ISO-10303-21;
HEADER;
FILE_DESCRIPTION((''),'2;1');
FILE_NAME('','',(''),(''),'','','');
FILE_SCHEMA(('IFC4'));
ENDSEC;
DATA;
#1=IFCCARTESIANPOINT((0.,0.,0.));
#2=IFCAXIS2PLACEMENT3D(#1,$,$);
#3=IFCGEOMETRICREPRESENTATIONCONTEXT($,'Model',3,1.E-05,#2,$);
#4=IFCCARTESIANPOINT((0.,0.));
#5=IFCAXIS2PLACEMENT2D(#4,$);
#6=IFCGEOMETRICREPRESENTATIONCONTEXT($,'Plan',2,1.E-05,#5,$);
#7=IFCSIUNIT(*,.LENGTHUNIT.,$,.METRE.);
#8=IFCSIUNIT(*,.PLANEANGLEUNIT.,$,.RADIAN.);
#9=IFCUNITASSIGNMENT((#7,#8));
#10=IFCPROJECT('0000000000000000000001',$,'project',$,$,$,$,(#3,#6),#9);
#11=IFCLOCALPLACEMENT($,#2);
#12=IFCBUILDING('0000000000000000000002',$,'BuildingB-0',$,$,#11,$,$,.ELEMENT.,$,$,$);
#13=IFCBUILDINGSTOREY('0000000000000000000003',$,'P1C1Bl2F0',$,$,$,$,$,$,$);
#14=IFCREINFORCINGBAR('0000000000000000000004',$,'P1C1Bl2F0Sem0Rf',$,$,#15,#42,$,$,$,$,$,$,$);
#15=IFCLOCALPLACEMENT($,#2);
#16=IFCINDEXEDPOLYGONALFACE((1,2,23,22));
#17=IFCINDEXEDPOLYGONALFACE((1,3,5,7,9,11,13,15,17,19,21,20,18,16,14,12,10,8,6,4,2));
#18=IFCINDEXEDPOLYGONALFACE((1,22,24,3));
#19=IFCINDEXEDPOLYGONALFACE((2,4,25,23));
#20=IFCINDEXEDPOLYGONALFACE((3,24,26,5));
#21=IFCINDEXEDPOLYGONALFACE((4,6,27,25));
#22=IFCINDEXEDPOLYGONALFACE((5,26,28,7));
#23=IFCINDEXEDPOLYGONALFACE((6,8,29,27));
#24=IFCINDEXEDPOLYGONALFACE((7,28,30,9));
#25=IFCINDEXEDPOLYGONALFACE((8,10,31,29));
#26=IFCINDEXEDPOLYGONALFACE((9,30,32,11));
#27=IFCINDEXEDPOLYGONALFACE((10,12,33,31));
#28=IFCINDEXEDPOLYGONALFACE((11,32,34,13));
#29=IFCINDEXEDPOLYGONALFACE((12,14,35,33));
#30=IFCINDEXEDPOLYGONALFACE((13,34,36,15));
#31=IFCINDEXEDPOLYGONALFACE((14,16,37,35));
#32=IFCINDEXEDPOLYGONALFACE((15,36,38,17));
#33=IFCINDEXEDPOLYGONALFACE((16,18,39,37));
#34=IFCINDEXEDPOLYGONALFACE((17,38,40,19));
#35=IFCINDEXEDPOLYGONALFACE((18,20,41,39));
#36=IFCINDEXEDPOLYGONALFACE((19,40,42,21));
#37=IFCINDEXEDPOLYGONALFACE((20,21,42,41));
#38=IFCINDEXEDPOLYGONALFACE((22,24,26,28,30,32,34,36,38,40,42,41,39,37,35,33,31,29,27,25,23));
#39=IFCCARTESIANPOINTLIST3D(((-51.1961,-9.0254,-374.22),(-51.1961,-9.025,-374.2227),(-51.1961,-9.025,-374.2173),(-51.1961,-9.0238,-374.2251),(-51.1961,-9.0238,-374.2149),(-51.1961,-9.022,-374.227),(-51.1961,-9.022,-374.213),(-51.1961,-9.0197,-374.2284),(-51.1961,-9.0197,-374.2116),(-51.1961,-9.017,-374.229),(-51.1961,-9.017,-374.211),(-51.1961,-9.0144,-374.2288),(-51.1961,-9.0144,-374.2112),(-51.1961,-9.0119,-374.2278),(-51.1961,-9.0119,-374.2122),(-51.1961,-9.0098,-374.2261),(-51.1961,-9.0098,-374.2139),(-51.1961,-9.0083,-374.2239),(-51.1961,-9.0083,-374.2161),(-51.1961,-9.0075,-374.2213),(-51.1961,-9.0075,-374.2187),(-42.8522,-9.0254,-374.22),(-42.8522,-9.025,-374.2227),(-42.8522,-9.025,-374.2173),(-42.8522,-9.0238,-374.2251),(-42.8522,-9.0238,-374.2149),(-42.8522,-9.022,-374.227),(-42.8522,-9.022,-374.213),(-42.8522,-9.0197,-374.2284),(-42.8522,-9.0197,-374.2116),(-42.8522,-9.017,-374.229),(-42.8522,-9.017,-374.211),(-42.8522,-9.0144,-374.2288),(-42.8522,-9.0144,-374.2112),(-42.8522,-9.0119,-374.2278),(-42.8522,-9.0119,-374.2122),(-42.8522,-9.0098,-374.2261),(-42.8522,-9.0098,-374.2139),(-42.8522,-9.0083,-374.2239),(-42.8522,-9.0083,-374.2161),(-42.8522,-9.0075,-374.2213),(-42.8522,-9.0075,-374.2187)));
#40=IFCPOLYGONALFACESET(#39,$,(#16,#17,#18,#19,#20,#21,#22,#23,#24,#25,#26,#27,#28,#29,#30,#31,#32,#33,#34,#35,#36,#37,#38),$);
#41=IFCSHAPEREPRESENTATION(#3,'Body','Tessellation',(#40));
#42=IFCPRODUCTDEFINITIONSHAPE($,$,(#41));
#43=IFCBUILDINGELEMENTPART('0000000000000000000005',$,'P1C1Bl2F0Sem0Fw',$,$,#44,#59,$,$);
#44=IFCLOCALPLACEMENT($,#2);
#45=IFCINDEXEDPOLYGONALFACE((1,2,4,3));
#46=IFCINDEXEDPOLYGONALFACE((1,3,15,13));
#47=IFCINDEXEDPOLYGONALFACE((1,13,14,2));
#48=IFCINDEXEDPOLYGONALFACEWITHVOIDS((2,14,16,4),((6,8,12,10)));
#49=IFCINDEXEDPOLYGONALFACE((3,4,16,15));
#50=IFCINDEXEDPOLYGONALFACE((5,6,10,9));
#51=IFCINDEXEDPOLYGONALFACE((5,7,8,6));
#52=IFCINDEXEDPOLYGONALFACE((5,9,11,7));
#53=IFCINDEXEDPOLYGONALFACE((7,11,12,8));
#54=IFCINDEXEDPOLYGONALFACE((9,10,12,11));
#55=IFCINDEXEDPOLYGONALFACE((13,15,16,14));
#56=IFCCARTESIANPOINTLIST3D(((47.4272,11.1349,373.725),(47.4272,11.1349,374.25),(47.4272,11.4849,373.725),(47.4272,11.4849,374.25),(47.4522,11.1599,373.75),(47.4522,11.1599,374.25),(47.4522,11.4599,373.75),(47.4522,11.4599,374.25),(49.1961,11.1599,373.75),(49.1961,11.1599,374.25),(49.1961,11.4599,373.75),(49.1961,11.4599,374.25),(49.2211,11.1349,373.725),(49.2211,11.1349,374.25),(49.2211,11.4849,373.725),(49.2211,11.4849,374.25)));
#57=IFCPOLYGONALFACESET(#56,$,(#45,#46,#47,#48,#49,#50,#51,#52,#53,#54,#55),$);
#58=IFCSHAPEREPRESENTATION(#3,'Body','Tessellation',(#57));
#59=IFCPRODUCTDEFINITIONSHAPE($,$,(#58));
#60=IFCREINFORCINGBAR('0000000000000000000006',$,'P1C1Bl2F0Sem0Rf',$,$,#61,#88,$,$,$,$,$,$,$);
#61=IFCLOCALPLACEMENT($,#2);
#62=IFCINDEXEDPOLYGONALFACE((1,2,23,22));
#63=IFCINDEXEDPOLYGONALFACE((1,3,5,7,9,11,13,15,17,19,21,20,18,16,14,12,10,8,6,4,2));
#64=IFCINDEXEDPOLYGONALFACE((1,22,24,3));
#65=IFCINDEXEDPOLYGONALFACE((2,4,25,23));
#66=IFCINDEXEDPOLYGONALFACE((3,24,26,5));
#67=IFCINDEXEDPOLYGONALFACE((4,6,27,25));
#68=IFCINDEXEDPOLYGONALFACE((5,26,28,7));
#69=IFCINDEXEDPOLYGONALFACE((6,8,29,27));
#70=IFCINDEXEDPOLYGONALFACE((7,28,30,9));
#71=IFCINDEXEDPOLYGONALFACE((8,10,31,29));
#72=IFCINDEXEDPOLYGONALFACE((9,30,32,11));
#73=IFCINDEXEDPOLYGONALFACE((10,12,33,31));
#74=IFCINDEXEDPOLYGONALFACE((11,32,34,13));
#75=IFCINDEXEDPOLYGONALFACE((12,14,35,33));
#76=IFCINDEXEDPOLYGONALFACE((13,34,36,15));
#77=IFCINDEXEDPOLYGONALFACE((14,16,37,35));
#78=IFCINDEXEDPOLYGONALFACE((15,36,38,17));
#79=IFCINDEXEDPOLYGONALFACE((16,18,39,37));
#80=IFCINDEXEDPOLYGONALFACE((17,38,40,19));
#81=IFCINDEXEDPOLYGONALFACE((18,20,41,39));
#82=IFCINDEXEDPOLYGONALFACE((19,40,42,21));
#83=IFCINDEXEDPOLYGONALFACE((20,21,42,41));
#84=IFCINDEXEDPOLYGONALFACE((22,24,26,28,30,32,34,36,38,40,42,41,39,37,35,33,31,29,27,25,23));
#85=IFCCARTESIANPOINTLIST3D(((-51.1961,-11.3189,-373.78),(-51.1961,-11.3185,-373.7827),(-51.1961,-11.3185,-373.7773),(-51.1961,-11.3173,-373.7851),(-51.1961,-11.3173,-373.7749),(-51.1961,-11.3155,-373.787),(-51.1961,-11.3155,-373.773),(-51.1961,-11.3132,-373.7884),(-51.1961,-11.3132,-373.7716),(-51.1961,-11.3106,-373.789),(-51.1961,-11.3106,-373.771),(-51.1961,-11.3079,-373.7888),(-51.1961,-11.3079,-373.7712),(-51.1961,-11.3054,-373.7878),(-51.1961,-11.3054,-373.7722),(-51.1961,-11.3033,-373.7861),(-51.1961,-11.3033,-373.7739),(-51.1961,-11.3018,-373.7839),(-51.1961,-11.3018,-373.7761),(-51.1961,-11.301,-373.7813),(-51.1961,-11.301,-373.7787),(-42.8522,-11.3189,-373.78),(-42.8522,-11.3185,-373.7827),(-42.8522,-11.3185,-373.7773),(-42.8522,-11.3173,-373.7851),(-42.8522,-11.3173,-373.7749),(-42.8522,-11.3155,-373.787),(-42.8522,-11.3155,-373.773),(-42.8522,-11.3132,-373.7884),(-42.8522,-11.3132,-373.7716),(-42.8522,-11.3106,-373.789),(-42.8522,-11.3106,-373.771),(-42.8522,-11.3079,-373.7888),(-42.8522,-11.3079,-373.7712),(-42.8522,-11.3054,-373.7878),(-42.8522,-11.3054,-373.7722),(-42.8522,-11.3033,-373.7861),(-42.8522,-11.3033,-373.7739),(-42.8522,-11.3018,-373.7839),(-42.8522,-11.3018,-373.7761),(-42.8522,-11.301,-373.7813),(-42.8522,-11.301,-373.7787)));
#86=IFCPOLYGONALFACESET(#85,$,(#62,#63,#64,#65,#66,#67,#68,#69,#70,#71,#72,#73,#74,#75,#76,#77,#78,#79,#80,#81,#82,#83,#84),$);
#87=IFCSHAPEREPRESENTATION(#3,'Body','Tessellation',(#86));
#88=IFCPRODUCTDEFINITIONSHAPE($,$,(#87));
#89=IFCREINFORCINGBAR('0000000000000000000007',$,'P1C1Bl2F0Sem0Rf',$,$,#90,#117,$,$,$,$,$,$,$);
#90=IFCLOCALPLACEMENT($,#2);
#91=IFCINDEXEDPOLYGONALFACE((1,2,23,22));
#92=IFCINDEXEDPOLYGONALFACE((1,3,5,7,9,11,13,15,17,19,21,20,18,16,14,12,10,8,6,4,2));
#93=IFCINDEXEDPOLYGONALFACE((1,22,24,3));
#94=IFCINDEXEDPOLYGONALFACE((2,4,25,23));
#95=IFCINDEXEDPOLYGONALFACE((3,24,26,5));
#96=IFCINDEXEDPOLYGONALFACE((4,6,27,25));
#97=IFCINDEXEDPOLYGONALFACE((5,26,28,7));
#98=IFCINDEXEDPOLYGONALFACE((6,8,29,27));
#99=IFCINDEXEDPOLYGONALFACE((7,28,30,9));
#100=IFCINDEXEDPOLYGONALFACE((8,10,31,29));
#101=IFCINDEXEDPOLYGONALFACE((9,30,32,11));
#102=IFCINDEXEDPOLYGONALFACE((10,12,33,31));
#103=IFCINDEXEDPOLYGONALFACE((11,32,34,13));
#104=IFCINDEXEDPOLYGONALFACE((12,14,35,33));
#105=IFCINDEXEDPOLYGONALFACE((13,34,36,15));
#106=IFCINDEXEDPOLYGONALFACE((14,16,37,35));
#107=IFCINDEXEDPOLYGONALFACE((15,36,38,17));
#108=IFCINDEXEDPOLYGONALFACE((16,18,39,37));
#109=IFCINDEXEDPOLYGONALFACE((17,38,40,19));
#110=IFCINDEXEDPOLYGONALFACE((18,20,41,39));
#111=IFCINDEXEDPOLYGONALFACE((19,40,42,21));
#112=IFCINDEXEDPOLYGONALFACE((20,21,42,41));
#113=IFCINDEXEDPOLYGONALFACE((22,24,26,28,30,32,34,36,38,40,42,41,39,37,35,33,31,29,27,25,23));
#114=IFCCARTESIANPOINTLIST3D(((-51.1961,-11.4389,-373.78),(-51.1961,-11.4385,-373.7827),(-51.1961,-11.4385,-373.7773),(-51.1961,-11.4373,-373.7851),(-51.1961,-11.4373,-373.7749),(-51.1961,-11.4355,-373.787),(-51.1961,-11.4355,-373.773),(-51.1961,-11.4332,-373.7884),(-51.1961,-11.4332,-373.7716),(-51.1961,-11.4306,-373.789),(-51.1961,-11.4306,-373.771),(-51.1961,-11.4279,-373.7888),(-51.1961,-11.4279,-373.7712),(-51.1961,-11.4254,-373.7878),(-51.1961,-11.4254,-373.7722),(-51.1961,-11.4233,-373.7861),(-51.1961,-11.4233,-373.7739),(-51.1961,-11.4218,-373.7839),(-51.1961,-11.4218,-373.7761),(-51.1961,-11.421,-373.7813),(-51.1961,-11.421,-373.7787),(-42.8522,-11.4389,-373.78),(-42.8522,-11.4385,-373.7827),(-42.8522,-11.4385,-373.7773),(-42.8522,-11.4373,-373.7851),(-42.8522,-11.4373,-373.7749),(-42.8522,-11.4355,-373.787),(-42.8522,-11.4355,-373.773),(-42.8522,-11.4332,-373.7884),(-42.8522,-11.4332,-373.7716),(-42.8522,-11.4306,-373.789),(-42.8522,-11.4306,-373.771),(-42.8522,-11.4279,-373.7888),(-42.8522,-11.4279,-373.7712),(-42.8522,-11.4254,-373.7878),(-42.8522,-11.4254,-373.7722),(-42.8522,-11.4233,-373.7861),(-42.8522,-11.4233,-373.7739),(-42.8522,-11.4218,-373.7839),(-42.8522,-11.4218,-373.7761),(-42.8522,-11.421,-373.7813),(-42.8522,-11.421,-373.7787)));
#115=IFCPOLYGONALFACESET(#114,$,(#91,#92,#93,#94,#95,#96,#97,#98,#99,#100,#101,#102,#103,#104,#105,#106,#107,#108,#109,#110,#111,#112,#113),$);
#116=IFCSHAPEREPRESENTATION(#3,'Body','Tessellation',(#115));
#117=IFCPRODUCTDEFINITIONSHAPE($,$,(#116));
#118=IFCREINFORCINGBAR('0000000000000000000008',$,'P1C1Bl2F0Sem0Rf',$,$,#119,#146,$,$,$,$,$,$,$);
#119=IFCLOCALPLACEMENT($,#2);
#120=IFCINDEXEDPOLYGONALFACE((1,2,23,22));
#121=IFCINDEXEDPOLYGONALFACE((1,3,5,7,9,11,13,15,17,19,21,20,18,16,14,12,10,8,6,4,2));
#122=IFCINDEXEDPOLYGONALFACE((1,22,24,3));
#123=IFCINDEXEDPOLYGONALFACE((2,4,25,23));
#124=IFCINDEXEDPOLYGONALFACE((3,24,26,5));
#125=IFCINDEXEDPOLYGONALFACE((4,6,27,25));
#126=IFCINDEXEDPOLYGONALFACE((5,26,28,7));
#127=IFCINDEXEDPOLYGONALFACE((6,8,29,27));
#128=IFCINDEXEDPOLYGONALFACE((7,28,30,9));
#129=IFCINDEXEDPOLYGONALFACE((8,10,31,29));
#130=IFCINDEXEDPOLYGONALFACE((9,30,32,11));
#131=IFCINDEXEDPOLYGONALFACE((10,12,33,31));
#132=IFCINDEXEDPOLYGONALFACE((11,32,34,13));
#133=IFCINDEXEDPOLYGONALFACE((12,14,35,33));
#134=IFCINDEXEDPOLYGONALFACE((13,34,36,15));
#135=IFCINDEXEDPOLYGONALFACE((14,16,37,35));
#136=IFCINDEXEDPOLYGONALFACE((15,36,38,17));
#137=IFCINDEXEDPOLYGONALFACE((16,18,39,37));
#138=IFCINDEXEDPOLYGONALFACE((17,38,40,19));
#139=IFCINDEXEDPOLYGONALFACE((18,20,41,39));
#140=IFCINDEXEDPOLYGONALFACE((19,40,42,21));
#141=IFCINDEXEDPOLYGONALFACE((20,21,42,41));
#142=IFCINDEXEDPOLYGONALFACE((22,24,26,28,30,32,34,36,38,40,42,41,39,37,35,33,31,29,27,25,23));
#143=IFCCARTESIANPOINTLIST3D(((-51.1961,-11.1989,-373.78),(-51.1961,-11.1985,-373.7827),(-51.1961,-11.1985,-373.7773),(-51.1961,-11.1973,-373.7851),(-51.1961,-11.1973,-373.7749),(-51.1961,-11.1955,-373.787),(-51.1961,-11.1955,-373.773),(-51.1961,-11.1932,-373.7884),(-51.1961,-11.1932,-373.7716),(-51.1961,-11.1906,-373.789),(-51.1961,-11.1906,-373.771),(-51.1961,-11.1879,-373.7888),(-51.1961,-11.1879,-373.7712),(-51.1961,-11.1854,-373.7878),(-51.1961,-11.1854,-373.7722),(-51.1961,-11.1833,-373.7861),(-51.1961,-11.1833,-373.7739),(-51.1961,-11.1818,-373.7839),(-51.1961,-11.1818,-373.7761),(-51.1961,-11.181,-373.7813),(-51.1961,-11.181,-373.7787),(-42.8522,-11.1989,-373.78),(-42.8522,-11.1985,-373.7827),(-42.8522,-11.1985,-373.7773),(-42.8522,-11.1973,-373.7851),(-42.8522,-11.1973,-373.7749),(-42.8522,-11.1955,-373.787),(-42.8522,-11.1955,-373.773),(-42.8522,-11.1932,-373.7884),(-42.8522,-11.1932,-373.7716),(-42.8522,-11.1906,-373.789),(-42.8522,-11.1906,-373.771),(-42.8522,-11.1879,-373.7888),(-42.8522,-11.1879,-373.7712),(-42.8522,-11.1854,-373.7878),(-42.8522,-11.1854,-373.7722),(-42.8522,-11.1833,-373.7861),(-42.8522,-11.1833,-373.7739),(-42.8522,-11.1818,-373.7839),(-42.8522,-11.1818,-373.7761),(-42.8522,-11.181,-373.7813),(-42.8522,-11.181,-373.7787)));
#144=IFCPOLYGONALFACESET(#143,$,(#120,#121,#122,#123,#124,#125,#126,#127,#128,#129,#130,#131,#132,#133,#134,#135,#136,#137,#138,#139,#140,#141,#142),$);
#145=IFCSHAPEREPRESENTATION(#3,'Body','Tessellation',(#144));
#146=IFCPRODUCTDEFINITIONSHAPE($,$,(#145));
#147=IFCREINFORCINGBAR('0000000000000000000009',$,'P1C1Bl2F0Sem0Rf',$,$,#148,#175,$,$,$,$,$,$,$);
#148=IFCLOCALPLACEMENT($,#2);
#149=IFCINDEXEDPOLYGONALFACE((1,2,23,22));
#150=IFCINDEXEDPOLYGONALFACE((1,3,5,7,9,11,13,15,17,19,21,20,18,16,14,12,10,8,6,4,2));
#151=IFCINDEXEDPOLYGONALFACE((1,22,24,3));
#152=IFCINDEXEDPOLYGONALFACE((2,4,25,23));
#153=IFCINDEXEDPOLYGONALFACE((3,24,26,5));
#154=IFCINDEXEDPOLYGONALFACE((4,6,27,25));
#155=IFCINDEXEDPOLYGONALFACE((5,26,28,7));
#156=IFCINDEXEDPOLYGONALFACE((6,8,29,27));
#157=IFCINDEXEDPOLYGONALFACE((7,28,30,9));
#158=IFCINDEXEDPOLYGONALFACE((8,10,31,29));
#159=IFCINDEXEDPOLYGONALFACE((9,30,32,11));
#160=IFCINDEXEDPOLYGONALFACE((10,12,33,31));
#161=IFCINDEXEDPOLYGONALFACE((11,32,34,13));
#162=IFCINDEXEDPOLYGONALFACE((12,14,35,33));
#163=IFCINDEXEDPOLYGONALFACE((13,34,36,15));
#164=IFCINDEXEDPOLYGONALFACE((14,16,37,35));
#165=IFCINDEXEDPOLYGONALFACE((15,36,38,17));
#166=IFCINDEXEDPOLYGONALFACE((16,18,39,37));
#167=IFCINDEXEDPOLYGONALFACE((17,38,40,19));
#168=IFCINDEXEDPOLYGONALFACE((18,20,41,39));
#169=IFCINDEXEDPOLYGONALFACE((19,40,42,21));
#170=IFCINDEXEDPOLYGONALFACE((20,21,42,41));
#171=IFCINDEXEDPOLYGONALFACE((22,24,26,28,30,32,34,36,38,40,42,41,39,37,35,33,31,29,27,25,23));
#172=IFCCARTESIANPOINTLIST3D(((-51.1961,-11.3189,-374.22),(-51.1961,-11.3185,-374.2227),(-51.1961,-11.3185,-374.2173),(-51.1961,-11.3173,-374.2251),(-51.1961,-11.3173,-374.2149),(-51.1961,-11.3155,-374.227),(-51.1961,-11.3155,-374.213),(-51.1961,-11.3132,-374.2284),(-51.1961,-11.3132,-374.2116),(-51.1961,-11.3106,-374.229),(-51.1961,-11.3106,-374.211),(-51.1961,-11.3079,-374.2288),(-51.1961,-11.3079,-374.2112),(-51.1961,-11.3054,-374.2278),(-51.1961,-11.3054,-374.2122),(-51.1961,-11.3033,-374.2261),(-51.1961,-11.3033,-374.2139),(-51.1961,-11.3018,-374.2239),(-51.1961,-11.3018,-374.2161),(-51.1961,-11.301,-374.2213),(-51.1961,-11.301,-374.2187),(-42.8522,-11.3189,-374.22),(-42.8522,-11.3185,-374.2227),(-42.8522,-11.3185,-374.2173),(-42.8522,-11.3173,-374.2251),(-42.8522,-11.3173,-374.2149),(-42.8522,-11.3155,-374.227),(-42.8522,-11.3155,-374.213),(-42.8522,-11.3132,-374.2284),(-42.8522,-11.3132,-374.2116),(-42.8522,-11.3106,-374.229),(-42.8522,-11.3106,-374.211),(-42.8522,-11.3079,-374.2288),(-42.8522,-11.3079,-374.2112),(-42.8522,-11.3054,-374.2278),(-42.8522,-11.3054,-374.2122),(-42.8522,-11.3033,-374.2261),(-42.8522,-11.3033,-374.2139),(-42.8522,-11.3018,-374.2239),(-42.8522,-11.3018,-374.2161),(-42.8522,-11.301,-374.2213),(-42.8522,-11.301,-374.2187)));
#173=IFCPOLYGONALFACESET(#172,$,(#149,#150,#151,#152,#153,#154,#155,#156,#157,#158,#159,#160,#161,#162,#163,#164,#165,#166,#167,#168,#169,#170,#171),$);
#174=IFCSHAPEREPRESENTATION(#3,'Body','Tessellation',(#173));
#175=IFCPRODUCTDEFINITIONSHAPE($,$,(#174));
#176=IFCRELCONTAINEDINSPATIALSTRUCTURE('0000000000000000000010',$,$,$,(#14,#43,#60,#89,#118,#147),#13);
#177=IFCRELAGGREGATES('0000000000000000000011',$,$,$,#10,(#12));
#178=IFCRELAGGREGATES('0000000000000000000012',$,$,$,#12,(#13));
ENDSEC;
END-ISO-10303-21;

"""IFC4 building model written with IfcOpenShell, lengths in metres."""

from ifc_helpers import new_model, entity, si_unit, origin, origin_2d, place, context, project, spatial, polyline, outline, extrude, element, save


model = new_model("IFC4")

# Units and contexts
model_context = context("Model", 3, precision=1e-05, world=origin())
plan_context = context("Plan", 2, precision=1e-05, world=origin_2d())
ifc_project = project(units=[si_unit("LENGTHUNIT", "METRE"), si_unit("PLANEANGLEUNIT", "RADIAN")], contexts=[model_context, plan_context])

# Building, storey
building_placement = place(None, origin())
building = spatial("IfcBuilding", under=ifc_project, at=building_placement, Name="BuildingB-0", CompositionType="ELEMENT")
storey = spatial("IfcBuildingStorey", under=building, Name="P1C1Bl2F0")

# Reinforcing bar
element("IfcReinforcingBar", 1, inside=storey, Name="P1C1Bl2F0Sem0Rf", context=model_context, shape_type="SweptSolid", body=[
    entity("IfcSurfaceCurveSweptAreaSolid", entity("IfcCircleProfileDef", "AREA", None, None, 0.009), None, entity("IfcPolyline", [entity("IfcCartesianPoint", [51.1961, 9.0164, 374.22]), entity("IfcCartesianPoint", [42.8522, 9.0164, 374.22])]), None, None, entity("IfcPlane", entity("IfcAxis2Placement3D", entity("IfcCartesianPoint", [51.1961, 9.0164, 374.22]), entity("IfcDirection", [0.0, 0.0, 1.0]), entity("IfcDirection", [1.0, 0.0, 0.0])))),
])

# Building element part, opening
building_element_part_1 = element("IfcBuildingElementPart", 2, inside=storey, Name="P1C1Bl2F0Sem0Fw", context=model_context, shape_type="SweptSolid", body=[
    extrude(outline(polyline([(47.4272, 11.1349, 373.725), (47.4272, 11.4849, 373.725), (49.2211, 11.4849, 373.725), (49.2211, 11.1349, 373.725), (47.4272, 11.1349, 373.725)])), None, (0.0, 0.0, 1.0), 0.525),
])
element("IfcOpeningElement", 3, inside=storey, cuts=building_element_part_1, context=model_context, shape_type="SweptSolid", body=[
    extrude(outline(polyline([(47.4522, 11.1599, 373.75), (47.4522, 11.4599, 373.75), (49.1961, 11.4599, 373.75), (49.1961, 11.1599, 373.75), (47.4522, 11.1599, 373.75)])), None, (0.0, 0.0, 1.0), 0.5),
])

# Reinforcing bars
element("IfcReinforcingBar", 4, inside=storey, Name="P1C1Bl2F0Sem0Rf", context=model_context, shape_type="SweptSolid", body=[
    entity("IfcSurfaceCurveSweptAreaSolid", entity("IfcCircleProfileDef", "AREA", None, None, 0.009), None, entity("IfcPolyline", [entity("IfcCartesianPoint", [51.1961, 11.3099, 373.78]), entity("IfcCartesianPoint", [42.8522, 11.3099, 373.78])]), None, None, entity("IfcPlane", entity("IfcAxis2Placement3D", entity("IfcCartesianPoint", [51.1961, 11.3099, 373.78]), entity("IfcDirection", [0.0, 0.0, 1.0]), entity("IfcDirection", [1.0, 0.0, 0.0])))),
])
element("IfcReinforcingBar", 5, inside=storey, Name="P1C1Bl2F0Sem0Rf", context=model_context, shape_type="SweptSolid", body=[
    entity("IfcSurfaceCurveSweptAreaSolid", entity("IfcCircleProfileDef", "AREA", None, None, 0.009), None, entity("IfcPolyline", [entity("IfcCartesianPoint", [51.1961, 11.4299, 373.78]), entity("IfcCartesianPoint", [42.8522, 11.4299, 373.78])]), None, None, entity("IfcPlane", entity("IfcAxis2Placement3D", entity("IfcCartesianPoint", [51.1961, 11.4299, 373.78]), entity("IfcDirection", [0.0, 0.0, 1.0]), entity("IfcDirection", [1.0, 0.0, 0.0])))),
])
element("IfcReinforcingBar", 6, inside=storey, Name="P1C1Bl2F0Sem0Rf", context=model_context, shape_type="SweptSolid", body=[
    entity("IfcSurfaceCurveSweptAreaSolid", entity("IfcCircleProfileDef", "AREA", None, None, 0.009), None, entity("IfcPolyline", [entity("IfcCartesianPoint", [51.1961, 11.1899, 373.78]), entity("IfcCartesianPoint", [42.8522, 11.1899, 373.78])]), None, None, entity("IfcPlane", entity("IfcAxis2Placement3D", entity("IfcCartesianPoint", [51.1961, 11.1899, 373.78]), entity("IfcDirection", [0.0, 0.0, 1.0]), entity("IfcDirection", [1.0, 0.0, 0.0])))),
])
element("IfcReinforcingBar", 7, inside=storey, Name="P1C1Bl2F0Sem0Rf", context=model_context, shape_type="SweptSolid", body=[
    entity("IfcSurfaceCurveSweptAreaSolid", entity("IfcCircleProfileDef", "AREA", None, None, 0.009), None, entity("IfcPolyline", [entity("IfcCartesianPoint", [51.1961, 11.3099, 374.22]), entity("IfcCartesianPoint", [42.8522, 11.3099, 374.22])]), None, None, entity("IfcPlane", entity("IfcAxis2Placement3D", entity("IfcCartesianPoint", [51.1961, 11.3099, 374.22]), entity("IfcDirection", [0.0, 0.0, 1.0]), entity("IfcDirection", [1.0, 0.0, 0.0])))),
])

save(model, "model.ifc")
